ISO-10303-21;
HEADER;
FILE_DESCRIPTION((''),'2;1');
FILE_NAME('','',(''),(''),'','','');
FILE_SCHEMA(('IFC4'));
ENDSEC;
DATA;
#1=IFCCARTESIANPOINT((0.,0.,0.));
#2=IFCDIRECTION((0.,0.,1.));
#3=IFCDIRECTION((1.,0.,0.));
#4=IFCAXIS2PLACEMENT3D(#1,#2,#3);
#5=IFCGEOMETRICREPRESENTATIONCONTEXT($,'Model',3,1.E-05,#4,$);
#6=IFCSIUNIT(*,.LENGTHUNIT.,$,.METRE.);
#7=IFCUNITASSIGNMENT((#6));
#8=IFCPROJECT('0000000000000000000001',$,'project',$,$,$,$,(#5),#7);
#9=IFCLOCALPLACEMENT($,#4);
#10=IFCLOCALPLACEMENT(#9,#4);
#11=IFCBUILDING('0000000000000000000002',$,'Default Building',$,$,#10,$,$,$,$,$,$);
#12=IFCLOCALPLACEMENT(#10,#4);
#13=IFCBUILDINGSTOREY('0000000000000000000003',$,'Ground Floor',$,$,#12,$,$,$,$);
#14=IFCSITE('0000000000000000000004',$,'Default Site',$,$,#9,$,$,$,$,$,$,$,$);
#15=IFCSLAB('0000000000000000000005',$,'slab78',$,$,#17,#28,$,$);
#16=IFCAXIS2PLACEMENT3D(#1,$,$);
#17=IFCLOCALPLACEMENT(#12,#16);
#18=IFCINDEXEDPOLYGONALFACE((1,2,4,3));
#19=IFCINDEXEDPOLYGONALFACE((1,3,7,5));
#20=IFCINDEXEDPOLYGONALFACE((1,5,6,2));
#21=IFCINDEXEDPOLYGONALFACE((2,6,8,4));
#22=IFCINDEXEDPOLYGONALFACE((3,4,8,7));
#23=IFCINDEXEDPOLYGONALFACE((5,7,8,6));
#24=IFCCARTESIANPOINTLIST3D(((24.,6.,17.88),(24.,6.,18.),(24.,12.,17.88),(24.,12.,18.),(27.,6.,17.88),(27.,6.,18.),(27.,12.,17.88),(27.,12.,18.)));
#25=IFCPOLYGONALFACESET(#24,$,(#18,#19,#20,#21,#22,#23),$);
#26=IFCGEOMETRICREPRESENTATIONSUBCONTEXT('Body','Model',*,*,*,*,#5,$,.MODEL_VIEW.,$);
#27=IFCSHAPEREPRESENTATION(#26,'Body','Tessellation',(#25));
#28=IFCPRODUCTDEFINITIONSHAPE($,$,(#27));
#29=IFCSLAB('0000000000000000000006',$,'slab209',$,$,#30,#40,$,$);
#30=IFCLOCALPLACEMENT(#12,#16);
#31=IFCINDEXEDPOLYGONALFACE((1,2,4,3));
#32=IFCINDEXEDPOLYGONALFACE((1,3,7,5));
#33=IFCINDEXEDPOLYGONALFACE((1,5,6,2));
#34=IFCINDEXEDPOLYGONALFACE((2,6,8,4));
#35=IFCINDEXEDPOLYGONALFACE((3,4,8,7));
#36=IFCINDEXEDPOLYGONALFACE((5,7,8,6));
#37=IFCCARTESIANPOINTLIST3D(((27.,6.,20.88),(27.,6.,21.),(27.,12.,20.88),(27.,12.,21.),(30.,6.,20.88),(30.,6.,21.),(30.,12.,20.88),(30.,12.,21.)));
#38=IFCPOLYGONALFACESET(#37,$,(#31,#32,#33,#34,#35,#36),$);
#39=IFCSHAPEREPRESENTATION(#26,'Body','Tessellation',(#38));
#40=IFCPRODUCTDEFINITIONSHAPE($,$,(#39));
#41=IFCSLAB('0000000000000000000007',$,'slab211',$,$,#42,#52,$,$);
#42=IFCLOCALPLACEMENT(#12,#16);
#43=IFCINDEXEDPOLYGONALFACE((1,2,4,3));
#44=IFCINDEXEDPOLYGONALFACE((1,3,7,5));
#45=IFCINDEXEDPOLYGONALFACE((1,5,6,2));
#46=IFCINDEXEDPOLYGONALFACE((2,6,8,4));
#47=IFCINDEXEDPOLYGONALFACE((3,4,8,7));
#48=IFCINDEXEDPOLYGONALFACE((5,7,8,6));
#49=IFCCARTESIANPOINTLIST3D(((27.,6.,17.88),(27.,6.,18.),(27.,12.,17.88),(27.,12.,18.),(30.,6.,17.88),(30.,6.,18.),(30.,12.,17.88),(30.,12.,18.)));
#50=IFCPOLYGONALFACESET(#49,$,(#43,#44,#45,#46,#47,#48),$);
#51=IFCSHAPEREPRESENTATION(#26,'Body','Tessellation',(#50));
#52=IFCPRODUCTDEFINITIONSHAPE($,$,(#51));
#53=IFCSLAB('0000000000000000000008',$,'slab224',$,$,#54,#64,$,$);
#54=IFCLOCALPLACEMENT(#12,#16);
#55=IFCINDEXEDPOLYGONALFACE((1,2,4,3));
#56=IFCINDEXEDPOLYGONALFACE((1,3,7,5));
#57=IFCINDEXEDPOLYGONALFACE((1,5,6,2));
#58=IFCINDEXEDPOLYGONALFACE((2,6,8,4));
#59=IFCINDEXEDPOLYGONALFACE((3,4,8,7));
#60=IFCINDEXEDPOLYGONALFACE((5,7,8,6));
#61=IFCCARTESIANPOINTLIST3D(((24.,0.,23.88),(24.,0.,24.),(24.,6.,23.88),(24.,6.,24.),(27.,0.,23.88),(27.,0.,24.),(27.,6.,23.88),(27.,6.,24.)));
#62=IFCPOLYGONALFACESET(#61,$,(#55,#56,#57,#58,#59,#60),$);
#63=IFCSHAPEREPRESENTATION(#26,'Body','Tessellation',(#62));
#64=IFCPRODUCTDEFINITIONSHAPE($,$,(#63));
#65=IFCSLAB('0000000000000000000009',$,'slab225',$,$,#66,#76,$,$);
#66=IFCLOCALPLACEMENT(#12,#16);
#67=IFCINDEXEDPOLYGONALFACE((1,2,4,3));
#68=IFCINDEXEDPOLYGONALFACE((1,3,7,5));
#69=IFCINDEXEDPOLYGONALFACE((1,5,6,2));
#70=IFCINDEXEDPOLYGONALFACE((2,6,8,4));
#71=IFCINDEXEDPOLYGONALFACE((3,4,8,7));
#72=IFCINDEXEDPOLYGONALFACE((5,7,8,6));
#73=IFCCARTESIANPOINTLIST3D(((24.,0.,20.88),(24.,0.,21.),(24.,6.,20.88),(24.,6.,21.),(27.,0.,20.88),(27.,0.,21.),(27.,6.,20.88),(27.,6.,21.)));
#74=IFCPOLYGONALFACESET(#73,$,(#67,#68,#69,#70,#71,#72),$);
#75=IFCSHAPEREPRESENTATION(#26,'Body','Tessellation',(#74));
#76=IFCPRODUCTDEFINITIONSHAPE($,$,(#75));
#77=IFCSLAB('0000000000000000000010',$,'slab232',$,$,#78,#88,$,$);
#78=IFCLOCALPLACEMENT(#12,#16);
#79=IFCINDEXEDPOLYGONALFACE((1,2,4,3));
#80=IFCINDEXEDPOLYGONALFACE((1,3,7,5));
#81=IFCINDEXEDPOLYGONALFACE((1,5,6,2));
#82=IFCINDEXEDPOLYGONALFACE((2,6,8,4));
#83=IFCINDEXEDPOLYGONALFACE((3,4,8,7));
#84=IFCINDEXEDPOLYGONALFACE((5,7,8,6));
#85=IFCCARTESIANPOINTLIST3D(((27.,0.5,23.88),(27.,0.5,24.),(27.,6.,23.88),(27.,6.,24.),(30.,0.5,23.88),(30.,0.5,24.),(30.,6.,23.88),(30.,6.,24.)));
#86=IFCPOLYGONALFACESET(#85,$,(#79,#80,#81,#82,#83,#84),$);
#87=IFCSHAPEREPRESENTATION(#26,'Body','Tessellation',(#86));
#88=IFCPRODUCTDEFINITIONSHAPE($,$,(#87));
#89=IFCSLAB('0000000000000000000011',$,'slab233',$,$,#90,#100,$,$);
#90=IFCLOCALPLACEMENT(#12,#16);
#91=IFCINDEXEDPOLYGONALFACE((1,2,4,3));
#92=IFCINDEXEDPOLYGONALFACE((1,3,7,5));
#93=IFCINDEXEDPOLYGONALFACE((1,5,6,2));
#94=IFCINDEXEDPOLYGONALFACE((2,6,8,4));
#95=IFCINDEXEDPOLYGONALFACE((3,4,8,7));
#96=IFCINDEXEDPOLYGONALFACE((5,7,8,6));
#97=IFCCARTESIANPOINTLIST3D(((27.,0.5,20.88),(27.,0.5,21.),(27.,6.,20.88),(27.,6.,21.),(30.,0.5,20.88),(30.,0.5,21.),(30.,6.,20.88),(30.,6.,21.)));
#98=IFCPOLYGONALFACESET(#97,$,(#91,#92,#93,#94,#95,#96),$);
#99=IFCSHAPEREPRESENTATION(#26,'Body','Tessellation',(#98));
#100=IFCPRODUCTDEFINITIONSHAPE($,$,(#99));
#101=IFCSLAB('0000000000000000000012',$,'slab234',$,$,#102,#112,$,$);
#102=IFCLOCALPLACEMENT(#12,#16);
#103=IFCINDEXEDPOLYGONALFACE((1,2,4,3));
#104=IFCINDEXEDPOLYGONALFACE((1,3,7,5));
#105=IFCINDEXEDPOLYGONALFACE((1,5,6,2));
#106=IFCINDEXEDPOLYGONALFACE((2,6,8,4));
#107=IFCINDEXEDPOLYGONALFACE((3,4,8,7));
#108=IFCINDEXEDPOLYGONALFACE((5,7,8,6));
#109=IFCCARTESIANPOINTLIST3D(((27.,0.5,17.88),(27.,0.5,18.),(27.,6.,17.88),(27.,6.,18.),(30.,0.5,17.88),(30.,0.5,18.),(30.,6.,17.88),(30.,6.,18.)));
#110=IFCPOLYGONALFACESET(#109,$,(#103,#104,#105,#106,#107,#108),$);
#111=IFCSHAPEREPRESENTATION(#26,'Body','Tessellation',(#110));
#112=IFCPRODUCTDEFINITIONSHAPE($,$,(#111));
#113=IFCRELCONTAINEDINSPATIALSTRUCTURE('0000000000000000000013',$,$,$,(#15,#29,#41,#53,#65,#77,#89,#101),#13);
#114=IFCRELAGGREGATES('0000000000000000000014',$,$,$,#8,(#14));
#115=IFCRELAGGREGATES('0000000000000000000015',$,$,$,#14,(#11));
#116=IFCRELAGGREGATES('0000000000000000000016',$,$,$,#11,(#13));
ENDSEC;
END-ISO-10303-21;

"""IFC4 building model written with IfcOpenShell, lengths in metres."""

from ifc_helpers import new_model, si_unit, frame, origin_with_axes, place, context, subcontext, project, spatial, indexed_curve, outline, extrude, element, save


model = new_model("IFC4")

# Units and contexts
model_context = context("Model", 3, precision=1e-05, world=origin_with_axes())
body_context = subcontext(model_context, "Body", "Model", "MODEL_VIEW")
ifc_project = project(units=[si_unit("LENGTHUNIT", "METRE")], contexts=[model_context])

# Site, building, storey
site_placement = place(None, origin_with_axes())
site = spatial("IfcSite", under=ifc_project, at=site_placement, Name="Default Site")
building_placement = place(site_placement, origin_with_axes())
building = spatial("IfcBuilding", under=site, at=building_placement, Name="Default Building")
storey_placement = place(building_placement, origin_with_axes())
storey = spatial("IfcBuildingStorey", under=building, at=storey_placement, Name="Ground Floor")

# Slabs
for number, where, z_axis, x_axis, name in (
    (1, (24.0, 6.0, 17.88), (0.0, 0.0, 1.0), (1.0, 0.0, 0.0), "slab78"),
    (2, (27.0, 6.0, 20.88), (0.0, 0.0, 1.0), (1.0, 0.0, 0.0), "slab209"),
    (3, (27.0, 6.0, 17.88), (0.0, 0.0, 1.0), (1.0, 0.0, 0.0), "slab211"),
    (4, (24.0, 0.0, 23.88), (0.0, 0.0, 1.0), (1.0, 0.0, 0.0), "slab224"),
    (5, (24.0, 0.0, 20.88), (0.0, 0.0, 1.0), (1.0, 0.0, 0.0), "slab225"),
):
    element("IfcSlab", number, at=place(storey_placement, frame(where, z_axis=z_axis, x_axis=x_axis)), inside=storey, Name=name, context=body_context, shape_type="SweptSolid", body=[
        extrude(outline(indexed_curve([(0.0, 0.0), (0.0, 6.0), (3.0, 6.0), (3.0, 0.0), (0.0, 0.0)], self_intersect=False)), origin_with_axes(), (0.0, 0.0, 1.0), 0.12),
    ])
for number, where, z_axis, x_axis, name in (
    (6, (27.0, 0.5, 23.88), (0.0, 0.0, 1.0), (1.0, 0.0, 0.0), "slab232"),
    (7, (27.0, 0.5, 20.88), (0.0, 0.0, 1.0), (1.0, 0.0, 0.0), "slab233"),
    (8, (27.0, 0.5, 17.88), (0.0, 0.0, 1.0), (1.0, 0.0, 0.0), "slab234"),
):
    element("IfcSlab", number, at=place(storey_placement, frame(where, z_axis=z_axis, x_axis=x_axis)), inside=storey, Name=name, context=body_context, shape_type="SweptSolid", body=[
        extrude(outline(indexed_curve([(0.0, 0.0), (0.0, 5.5), (3.0, 5.5), (3.0, 0.0), (0.0, 0.0)], self_intersect=False)), origin_with_axes(), (0.0, 0.0, 1.0), 0.12),
    ])

save(model, "model.ifc")
